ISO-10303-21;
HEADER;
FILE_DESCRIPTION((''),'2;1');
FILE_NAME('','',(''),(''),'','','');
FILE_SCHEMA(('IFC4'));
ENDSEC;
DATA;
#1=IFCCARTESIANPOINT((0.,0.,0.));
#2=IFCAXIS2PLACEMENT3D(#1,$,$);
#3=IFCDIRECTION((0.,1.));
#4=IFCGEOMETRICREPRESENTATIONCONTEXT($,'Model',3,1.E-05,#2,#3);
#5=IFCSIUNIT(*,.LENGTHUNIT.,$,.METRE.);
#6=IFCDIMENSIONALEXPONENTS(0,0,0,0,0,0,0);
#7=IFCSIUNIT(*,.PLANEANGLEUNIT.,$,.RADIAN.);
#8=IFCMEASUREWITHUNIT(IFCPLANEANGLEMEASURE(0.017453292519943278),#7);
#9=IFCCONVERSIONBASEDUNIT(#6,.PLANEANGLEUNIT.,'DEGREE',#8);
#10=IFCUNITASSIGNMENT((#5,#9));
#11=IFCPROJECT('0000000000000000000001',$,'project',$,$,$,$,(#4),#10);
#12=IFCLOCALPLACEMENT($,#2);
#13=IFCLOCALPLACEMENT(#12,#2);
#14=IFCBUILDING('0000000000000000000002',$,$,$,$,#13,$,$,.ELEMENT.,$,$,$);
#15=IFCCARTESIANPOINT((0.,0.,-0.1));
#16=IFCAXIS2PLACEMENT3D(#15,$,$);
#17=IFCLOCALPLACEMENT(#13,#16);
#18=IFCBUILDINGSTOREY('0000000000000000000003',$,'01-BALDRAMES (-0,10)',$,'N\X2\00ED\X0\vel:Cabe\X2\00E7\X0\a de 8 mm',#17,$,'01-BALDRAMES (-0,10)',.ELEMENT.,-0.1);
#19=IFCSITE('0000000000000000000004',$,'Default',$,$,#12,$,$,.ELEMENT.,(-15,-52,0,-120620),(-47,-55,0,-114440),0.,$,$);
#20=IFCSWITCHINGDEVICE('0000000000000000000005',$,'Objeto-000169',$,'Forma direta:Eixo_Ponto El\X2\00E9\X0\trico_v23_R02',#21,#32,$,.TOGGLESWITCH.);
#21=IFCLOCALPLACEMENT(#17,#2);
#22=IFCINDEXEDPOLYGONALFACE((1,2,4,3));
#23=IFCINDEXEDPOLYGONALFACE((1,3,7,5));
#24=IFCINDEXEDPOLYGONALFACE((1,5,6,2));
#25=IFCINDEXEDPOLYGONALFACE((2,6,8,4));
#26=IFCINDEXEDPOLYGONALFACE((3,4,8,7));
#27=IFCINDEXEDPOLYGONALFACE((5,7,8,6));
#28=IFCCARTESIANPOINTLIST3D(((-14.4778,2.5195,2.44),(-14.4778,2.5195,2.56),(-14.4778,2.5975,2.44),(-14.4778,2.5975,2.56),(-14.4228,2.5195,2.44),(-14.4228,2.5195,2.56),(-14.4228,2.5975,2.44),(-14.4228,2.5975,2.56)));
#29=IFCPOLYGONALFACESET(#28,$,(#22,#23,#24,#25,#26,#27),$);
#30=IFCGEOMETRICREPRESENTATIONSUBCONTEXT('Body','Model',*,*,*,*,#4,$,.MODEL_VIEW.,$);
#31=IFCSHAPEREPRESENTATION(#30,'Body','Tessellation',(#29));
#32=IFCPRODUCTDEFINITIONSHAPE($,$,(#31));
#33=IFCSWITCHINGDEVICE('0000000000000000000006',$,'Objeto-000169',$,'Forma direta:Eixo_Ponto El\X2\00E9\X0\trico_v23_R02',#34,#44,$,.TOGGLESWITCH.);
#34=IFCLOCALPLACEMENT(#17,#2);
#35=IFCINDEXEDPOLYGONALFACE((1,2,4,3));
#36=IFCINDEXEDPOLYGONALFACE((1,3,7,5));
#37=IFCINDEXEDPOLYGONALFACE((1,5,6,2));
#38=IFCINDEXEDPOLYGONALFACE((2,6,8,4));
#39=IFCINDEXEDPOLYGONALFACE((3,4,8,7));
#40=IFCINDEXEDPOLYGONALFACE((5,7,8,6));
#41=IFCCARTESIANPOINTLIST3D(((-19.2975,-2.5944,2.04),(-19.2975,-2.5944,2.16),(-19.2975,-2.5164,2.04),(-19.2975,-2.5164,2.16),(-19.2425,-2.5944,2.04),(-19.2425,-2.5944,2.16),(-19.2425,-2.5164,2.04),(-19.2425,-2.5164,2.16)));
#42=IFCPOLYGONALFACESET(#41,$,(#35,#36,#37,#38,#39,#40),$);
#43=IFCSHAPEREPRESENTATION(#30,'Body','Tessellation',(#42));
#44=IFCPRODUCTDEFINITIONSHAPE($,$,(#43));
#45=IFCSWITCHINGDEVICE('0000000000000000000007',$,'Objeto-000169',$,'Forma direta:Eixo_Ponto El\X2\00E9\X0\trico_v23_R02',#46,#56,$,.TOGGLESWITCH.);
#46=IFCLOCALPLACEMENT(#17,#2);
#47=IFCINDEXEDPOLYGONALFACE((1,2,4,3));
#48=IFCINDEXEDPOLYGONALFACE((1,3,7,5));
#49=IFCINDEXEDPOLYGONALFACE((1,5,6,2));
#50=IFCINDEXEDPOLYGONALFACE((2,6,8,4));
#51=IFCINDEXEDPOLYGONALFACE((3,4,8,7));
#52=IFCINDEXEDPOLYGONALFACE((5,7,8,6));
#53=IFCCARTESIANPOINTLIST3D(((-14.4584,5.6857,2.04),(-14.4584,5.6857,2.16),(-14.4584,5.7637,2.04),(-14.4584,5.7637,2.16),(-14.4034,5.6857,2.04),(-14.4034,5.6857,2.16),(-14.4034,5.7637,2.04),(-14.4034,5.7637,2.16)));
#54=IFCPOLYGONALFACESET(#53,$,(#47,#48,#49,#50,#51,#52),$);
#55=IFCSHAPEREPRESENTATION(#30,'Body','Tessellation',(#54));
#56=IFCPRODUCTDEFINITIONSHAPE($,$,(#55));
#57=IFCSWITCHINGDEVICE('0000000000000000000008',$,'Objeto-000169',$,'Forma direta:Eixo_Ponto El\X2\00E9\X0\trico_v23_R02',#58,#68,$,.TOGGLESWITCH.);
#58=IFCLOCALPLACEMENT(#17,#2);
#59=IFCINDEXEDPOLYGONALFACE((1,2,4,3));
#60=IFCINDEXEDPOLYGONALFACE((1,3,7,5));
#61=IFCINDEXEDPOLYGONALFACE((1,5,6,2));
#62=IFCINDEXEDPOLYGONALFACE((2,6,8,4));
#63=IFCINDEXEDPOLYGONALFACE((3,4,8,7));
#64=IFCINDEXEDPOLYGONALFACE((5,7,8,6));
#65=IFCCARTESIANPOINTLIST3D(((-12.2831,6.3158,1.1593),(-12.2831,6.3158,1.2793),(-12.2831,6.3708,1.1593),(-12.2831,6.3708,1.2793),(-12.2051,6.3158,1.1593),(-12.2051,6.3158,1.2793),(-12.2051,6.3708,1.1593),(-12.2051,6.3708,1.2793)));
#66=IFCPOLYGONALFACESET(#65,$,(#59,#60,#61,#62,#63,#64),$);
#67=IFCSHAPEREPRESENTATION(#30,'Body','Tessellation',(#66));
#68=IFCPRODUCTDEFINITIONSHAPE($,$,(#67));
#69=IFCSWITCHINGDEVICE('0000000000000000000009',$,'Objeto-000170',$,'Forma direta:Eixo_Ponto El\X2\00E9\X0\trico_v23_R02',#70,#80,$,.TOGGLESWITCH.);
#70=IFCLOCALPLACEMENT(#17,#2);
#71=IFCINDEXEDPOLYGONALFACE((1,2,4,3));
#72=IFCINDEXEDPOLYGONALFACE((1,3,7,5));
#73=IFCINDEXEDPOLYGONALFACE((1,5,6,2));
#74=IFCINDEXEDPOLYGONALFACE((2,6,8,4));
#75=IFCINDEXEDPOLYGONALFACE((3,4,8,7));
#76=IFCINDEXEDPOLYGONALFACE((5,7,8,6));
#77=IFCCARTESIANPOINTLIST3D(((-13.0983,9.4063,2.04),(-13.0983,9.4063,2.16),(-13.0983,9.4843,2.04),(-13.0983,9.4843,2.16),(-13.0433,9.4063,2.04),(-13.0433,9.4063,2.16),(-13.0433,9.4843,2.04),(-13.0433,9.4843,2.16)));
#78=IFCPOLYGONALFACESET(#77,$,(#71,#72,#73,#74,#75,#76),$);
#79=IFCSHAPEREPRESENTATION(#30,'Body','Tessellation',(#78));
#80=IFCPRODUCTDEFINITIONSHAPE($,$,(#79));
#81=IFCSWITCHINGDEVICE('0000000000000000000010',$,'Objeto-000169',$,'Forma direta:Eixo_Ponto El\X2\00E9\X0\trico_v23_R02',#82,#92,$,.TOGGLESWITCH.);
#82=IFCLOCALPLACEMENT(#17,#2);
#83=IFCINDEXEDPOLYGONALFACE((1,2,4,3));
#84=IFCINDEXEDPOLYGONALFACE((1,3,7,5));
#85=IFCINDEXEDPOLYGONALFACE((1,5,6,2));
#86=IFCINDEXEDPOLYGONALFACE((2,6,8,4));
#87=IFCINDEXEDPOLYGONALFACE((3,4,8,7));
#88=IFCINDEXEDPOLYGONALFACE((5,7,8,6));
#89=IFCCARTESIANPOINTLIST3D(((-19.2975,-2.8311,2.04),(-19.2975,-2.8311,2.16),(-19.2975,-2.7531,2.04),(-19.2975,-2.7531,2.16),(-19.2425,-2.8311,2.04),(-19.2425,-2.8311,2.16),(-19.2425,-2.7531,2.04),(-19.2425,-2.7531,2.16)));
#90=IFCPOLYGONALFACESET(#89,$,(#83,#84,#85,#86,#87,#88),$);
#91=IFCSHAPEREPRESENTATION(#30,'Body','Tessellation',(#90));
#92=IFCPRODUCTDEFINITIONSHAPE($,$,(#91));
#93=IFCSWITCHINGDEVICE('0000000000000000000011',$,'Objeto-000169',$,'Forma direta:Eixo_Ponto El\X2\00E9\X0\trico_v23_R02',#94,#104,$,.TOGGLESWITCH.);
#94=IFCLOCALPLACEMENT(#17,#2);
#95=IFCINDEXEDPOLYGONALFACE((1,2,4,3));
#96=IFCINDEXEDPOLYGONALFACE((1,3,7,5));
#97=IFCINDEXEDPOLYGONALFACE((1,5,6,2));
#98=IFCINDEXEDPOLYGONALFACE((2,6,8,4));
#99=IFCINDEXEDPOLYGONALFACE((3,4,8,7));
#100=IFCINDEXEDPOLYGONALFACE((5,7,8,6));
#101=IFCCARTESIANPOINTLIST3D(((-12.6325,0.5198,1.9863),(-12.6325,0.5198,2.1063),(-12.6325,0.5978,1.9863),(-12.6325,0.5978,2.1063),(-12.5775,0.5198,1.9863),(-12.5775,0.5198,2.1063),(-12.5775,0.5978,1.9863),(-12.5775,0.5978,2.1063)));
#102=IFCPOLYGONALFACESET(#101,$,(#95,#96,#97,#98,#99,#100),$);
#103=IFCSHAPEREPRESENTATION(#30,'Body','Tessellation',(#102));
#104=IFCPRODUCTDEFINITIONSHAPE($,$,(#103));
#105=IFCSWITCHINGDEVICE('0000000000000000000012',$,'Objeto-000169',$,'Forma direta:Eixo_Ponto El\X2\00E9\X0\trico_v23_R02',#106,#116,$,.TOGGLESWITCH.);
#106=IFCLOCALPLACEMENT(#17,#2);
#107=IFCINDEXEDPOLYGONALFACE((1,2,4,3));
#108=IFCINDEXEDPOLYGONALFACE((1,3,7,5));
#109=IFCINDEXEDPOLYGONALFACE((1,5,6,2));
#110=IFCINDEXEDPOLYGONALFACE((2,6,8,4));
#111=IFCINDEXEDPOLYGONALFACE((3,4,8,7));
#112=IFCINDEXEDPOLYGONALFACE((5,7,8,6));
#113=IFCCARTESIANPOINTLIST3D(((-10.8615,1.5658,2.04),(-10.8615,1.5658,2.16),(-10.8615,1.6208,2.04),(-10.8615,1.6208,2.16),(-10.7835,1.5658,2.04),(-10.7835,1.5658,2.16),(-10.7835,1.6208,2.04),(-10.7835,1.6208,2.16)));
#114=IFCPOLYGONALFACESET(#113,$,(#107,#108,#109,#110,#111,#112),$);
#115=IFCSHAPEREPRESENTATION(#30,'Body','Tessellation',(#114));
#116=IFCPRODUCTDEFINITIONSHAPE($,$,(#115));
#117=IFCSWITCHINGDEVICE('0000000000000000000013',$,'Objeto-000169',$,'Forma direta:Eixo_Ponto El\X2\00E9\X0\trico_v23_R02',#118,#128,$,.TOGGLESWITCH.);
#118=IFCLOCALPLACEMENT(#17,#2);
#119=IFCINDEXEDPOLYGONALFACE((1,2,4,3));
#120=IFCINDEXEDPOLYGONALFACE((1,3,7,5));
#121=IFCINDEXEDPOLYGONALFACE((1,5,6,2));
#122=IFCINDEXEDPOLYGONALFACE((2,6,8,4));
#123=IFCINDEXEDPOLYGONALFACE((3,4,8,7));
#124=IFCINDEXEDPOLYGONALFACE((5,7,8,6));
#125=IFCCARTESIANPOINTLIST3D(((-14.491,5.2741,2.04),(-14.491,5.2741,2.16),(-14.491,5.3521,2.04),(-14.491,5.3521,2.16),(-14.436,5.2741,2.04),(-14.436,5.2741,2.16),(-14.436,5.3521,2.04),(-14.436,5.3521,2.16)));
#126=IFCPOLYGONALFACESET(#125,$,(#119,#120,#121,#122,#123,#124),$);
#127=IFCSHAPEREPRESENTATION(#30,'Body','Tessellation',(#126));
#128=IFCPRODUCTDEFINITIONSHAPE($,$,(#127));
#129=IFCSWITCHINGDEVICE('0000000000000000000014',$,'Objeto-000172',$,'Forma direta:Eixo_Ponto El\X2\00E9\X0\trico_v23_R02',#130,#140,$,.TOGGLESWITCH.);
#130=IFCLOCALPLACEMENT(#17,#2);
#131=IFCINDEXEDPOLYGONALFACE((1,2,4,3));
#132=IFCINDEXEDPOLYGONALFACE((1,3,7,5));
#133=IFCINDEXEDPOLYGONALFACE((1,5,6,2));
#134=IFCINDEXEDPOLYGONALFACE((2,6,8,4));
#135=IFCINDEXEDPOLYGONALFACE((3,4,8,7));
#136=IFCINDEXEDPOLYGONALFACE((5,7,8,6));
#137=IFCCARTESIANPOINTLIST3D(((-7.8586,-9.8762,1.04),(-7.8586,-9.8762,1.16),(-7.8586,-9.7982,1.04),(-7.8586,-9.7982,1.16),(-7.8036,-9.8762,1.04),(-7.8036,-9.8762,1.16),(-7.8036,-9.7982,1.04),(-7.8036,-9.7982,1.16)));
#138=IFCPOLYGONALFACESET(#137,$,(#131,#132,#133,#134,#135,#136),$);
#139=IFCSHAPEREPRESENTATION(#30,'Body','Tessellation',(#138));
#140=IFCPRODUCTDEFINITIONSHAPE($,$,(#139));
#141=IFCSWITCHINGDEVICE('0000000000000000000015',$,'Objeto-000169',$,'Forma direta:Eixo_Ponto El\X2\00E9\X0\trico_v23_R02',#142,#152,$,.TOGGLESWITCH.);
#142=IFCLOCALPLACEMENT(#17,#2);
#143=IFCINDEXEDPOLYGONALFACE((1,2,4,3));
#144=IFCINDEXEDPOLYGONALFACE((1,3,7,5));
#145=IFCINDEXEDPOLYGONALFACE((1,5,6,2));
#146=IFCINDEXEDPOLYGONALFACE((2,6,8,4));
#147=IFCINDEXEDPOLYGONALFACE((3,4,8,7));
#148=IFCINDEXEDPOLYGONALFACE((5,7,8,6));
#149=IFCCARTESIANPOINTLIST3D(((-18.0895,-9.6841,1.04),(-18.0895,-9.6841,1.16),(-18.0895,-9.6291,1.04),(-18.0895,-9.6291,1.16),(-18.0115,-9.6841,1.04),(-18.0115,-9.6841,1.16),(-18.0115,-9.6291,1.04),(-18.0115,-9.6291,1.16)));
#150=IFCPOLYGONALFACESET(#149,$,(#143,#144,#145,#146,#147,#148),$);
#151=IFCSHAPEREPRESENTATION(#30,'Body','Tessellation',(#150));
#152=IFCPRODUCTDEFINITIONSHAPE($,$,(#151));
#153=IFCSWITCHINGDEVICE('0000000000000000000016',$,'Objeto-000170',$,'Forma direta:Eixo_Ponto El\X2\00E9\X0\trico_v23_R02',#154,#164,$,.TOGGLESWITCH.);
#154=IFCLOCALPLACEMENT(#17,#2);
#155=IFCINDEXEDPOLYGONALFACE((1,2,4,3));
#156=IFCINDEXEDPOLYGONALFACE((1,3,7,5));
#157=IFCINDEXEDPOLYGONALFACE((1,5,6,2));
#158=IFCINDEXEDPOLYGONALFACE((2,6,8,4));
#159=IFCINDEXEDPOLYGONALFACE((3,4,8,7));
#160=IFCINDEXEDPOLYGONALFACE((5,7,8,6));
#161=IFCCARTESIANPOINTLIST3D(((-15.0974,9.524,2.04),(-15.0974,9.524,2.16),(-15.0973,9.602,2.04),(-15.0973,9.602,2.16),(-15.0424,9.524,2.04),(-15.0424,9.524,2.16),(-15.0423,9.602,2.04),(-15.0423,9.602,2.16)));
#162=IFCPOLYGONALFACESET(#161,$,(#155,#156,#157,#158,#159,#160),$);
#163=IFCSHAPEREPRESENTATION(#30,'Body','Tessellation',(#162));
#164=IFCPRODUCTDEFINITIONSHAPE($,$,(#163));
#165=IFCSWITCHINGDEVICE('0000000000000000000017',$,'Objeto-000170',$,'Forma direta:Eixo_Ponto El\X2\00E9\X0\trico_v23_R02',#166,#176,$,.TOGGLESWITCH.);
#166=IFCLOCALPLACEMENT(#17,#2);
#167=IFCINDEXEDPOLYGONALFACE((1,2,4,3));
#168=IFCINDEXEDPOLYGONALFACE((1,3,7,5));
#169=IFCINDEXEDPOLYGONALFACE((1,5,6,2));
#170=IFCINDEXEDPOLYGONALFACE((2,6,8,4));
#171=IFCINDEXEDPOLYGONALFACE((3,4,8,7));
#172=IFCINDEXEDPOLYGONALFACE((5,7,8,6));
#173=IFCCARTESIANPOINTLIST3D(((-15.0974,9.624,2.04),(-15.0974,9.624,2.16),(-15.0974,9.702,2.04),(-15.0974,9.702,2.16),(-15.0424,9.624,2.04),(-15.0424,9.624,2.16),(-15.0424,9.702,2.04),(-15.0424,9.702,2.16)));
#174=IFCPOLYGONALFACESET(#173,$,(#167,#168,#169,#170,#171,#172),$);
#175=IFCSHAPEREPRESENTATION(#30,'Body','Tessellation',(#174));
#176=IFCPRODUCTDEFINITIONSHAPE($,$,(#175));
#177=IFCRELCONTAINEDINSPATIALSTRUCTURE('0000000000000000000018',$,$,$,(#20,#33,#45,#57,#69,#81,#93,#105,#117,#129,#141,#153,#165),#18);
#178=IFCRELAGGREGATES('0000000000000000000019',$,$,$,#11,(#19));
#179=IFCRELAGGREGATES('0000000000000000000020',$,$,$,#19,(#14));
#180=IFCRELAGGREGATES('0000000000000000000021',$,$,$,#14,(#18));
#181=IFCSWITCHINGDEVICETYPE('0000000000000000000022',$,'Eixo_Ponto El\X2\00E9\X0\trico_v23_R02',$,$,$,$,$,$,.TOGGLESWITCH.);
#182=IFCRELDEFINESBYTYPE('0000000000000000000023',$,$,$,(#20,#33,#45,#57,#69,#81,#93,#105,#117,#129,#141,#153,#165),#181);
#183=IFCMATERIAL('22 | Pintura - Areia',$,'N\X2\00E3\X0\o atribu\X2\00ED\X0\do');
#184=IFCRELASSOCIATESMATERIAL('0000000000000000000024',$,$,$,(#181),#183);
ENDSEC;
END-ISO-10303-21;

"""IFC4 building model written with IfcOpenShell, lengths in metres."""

from ifc_helpers import new_model, entity, si_unit, converted_unit, direction, frame, origin, place, context, subcontext, project, spatial, indexed_curve, outline, extrude, material, type_object, element, save


model = new_model("IFC4")

# Units and contexts
model_context = context("Model", 3, precision=1e-05, world=origin(), true_north=direction((0.0, 1.0)))
body_context = subcontext(model_context, "Body", "Model", "MODEL_VIEW")
ifc_project = project(units=[si_unit("LENGTHUNIT", "METRE"), converted_unit("PLANEANGLEUNIT", "DEGREE", entity("IfcPlaneAngleMeasure", 0.017453292519943278), si_unit("PLANEANGLEUNIT", "RADIAN"), dimensions=[0, 0, 0, 0, 0, 0, 0])], contexts=[model_context])

# Site, building, storey
site_placement = place(None, origin())
site = spatial("IfcSite", under=ifc_project, at=site_placement, Name="Default", CompositionType="ELEMENT", RefLatitude=(-15, -52, 0, -120620), RefLongitude=(-47, -55, 0, -114440), RefElevation=0.0)
building_placement = place(site_placement, origin())
building = spatial("IfcBuilding", under=site, at=building_placement, CompositionType="ELEMENT")
storey_placement = place(building_placement, frame((0.0, 0.0, -0.1)))
storey = spatial("IfcBuildingStorey", under=building, at=storey_placement, Name="01-BALDRAMES (-0,10)", ObjectType="Nível:Cabeça de 8 mm", LongName="01-BALDRAMES (-0,10)", CompositionType="ELEMENT", Elevation=-0.1)

# Switching devices
ifc_material_1 = material(Name="22 | Pintura - Areia", Category="Não atribuído")
switching_device_type_1 = type_object("IfcSwitchingDeviceType", Name="Eixo_Ponto Elétrico_v23_R02", PredefinedType="TOGGLESWITCH", material=ifc_material_1)
switching_device_1_placement = place(storey_placement, origin())
element("IfcSwitchingDevice", 1, at=switching_device_1_placement, inside=storey, type_object=switching_device_type_1, Name="Objeto-000169", ObjectType="Forma direta:Eixo_Ponto Elétrico_v23_R02", PredefinedType="TOGGLESWITCH", context=body_context, shape_type="SweptSolid", body=[
    extrude(outline(indexed_curve([(-0.0275, -0.039), (0.0275, -0.039), (0.0275, 0.039), (-0.0275, 0.039), (-0.0275, -0.039)], self_intersect=False)), frame((-14.4503, 2.5585, 2.44)), (0.0, 0.0, 1.0), 0.12),
])
switching_device_2_placement = place(storey_placement, origin())
element("IfcSwitchingDevice", 2, at=switching_device_2_placement, inside=storey, type_object=switching_device_type_1, Name="Objeto-000169", ObjectType="Forma direta:Eixo_Ponto Elétrico_v23_R02", PredefinedType="TOGGLESWITCH", context=body_context, shape_type="SweptSolid", body=[
    extrude(outline(indexed_curve([(-0.0275, -0.039), (0.0275, -0.039), (0.0275, 0.039), (-0.0275, 0.039), (-0.0275, -0.039)], self_intersect=False)), frame((-19.27, -2.5554, 2.04), z_axis=(0.0, 0.0, 1.0), x_axis=(-1.0, 0.000013, 0.0)), (0.0, 0.0, 1.0), 0.12),
])
switching_device_3_placement = place(storey_placement, origin())
element("IfcSwitchingDevice", 3, at=switching_device_3_placement, inside=storey, type_object=switching_device_type_1, Name="Objeto-000169", ObjectType="Forma direta:Eixo_Ponto Elétrico_v23_R02", PredefinedType="TOGGLESWITCH", context=body_context, shape_type="SweptSolid", body=[
    extrude(outline(indexed_curve([(-0.0275, -0.039), (0.0275, -0.039), (0.0275, 0.039), (-0.0275, 0.039), (-0.0275, -0.039)], self_intersect=False)), frame((-14.4309, 5.7247, 2.04)), (0.0, 0.0, 1.0), 0.12),
])
switching_device_4_placement = place(storey_placement, origin())
element("IfcSwitchingDevice", 4, at=switching_device_4_placement, inside=storey, type_object=switching_device_type_1, Name="Objeto-000169", ObjectType="Forma direta:Eixo_Ponto Elétrico_v23_R02", PredefinedType="TOGGLESWITCH", context=body_context, shape_type="SweptSolid", body=[
    extrude(outline(indexed_curve([(-0.0275, -0.039), (0.0275, -0.039), (0.0275, 0.039), (-0.0275, 0.039), (-0.0275, -0.039)], self_intersect=False)), frame((-12.2441, 6.3433, 1.1593), z_axis=(0.0, 0.0, 1.0), x_axis=(-0.000013, -1.0, 0.0)), (0.0, 0.0, 1.0), 0.12),
])
switching_device_5_placement = place(storey_placement, origin())
element("IfcSwitchingDevice", 5, at=switching_device_5_placement, inside=storey, type_object=switching_device_type_1, Name="Objeto-000170", ObjectType="Forma direta:Eixo_Ponto Elétrico_v23_R02", PredefinedType="TOGGLESWITCH", context=body_context, shape_type="SweptSolid", body=[
    extrude(outline(indexed_curve([(-0.039, -0.0275), (0.039, -0.0275), (0.039, 0.0275), (-0.039, 0.0275), (-0.039, -0.0275)], self_intersect=False)), frame((-13.0708, 9.4453, 2.04), z_axis=(0.0, 0.0, 1.0), x_axis=(0.000013, 1.0, 0.0)), (0.0, 0.0, 1.0), 0.12),
])
switching_device_6_placement = place(storey_placement, origin())
element("IfcSwitchingDevice", 6, at=switching_device_6_placement, inside=storey, type_object=switching_device_type_1, Name="Objeto-000169", ObjectType="Forma direta:Eixo_Ponto Elétrico_v23_R02", PredefinedType="TOGGLESWITCH", context=body_context, shape_type="SweptSolid", body=[
    extrude(outline(indexed_curve([(-0.0275, -0.039), (0.0275, -0.039), (0.0275, 0.039), (-0.0275, 0.039), (-0.0275, -0.039)], self_intersect=False)), frame((-19.27, -2.7921, 2.04), z_axis=(0.0, 0.0, 1.0), x_axis=(-1.0, 0.000013, 0.0)), (0.0, 0.0, 1.0), 0.12),
])
switching_device_7_placement = place(storey_placement, origin())
element("IfcSwitchingDevice", 7, at=switching_device_7_placement, inside=storey, type_object=switching_device_type_1, Name="Objeto-000169", ObjectType="Forma direta:Eixo_Ponto Elétrico_v23_R02", PredefinedType="TOGGLESWITCH", context=body_context, shape_type="SweptSolid", body=[
    extrude(outline(indexed_curve([(-0.0275, -0.039), (0.0275, -0.039), (0.0275, 0.039), (-0.0275, 0.039), (-0.0275, -0.039)], self_intersect=False)), frame((-12.605, 0.5588, 1.9863), z_axis=(0.0, 0.0, 1.0), x_axis=(-1.0, 0.000011, 0.0)), (0.0, 0.0, 1.0), 0.12),
])
switching_device_8_placement = place(storey_placement, origin())
element("IfcSwitchingDevice", 8, at=switching_device_8_placement, inside=storey, type_object=switching_device_type_1, Name="Objeto-000169", ObjectType="Forma direta:Eixo_Ponto Elétrico_v23_R02", PredefinedType="TOGGLESWITCH", context=body_context, shape_type="SweptSolid", body=[
    extrude(outline(indexed_curve([(-0.0275, -0.039), (0.0275, -0.039), (0.0275, 0.039), (-0.0275, 0.039), (-0.0275, -0.039)], self_intersect=False)), frame((-10.8225, 1.5933, 2.04), z_axis=(0.0, 0.0, 1.0), x_axis=(-0.000013, -1.0, 0.0)), (0.0, 0.0, 1.0), 0.12),
])
switching_device_9_placement = place(storey_placement, origin())
element("IfcSwitchingDevice", 9, at=switching_device_9_placement, inside=storey, type_object=switching_device_type_1, Name="Objeto-000169", ObjectType="Forma direta:Eixo_Ponto Elétrico_v23_R02", PredefinedType="TOGGLESWITCH", context=body_context, shape_type="SweptSolid", body=[
    extrude(outline(indexed_curve([(-0.0275, -0.039), (0.0275, -0.039), (0.0275, 0.039), (-0.0275, 0.039), (-0.0275, -0.039)], self_intersect=False)), frame((-14.4635, 5.3131, 2.04)), (0.0, 0.0, 1.0), 0.12),
])
switching_device_10_placement = place(storey_placement, origin())
element("IfcSwitchingDevice", 10, at=switching_device_10_placement, inside=storey, type_object=switching_device_type_1, Name="Objeto-000172", ObjectType="Forma direta:Eixo_Ponto Elétrico_v23_R02", PredefinedType="TOGGLESWITCH", context=body_context, shape_type="SweptSolid", body=[
    extrude(outline(indexed_curve([(-0.0275, -0.039), (0.0275, -0.039), (0.0275, 0.039), (-0.0275, 0.039), (-0.0275, -0.039)], self_intersect=False)), frame((-7.8311, -9.8372, 1.04), z_axis=(0.0, 0.0, 1.0), x_axis=(1.0, 0.000186, 0.0)), (0.0, 0.0, 1.0), 0.12),
])
switching_device_11_placement = place(storey_placement, origin())
element("IfcSwitchingDevice", 11, at=switching_device_11_placement, inside=storey, type_object=switching_device_type_1, Name="Objeto-000169", ObjectType="Forma direta:Eixo_Ponto Elétrico_v23_R02", PredefinedType="TOGGLESWITCH", context=body_context, shape_type="SweptSolid", body=[
    extrude(outline(indexed_curve([(-0.0275, -0.039), (0.0275, -0.039), (0.0275, 0.039), (-0.0275, 0.039), (-0.0275, -0.039)], self_intersect=False)), frame((-18.0505, -9.6566, 1.04), z_axis=(0.0, 0.0, 1.0), x_axis=(-0.000011, -1.0, 0.0)), (0.0, 0.0, 1.0), 0.12),
])
switching_device_12_placement = place(storey_placement, origin())
element("IfcSwitchingDevice", 12, at=switching_device_12_placement, inside=storey, type_object=switching_device_type_1, Name="Objeto-000170", ObjectType="Forma direta:Eixo_Ponto Elétrico_v23_R02", PredefinedType="TOGGLESWITCH", context=body_context, shape_type="SweptSolid", body=[
    extrude(outline(indexed_curve([(-0.0275, -0.039), (0.0275, -0.039), (0.0275, 0.039), (-0.0275, 0.039), (-0.0275, -0.039)], self_intersect=False)), frame((-15.0699, 9.563, 2.04), z_axis=(0.0, 0.0, 1.0), x_axis=(-1.0, 0.000013, 0.0)), (0.0, 0.0, 1.0), 0.12),
])
switching_device_13_placement = place(storey_placement, origin())
element("IfcSwitchingDevice", 13, at=switching_device_13_placement, inside=storey, type_object=switching_device_type_1, Name="Objeto-000170", ObjectType="Forma direta:Eixo_Ponto Elétrico_v23_R02", PredefinedType="TOGGLESWITCH", context=body_context, shape_type="SweptSolid", body=[
    extrude(outline(indexed_curve([(-0.039, -0.0275), (0.039, -0.0275), (0.039, 0.0275), (-0.039, 0.0275), (-0.039, -0.0275)], self_intersect=False)), frame((-15.0699, 9.663, 2.04), z_axis=(0.0, 0.0, 1.0), x_axis=(-0.000001, 1.0, 0.0)), (0.0, 0.0, 1.0), 0.12),
])

save(model, "model.ifc")
